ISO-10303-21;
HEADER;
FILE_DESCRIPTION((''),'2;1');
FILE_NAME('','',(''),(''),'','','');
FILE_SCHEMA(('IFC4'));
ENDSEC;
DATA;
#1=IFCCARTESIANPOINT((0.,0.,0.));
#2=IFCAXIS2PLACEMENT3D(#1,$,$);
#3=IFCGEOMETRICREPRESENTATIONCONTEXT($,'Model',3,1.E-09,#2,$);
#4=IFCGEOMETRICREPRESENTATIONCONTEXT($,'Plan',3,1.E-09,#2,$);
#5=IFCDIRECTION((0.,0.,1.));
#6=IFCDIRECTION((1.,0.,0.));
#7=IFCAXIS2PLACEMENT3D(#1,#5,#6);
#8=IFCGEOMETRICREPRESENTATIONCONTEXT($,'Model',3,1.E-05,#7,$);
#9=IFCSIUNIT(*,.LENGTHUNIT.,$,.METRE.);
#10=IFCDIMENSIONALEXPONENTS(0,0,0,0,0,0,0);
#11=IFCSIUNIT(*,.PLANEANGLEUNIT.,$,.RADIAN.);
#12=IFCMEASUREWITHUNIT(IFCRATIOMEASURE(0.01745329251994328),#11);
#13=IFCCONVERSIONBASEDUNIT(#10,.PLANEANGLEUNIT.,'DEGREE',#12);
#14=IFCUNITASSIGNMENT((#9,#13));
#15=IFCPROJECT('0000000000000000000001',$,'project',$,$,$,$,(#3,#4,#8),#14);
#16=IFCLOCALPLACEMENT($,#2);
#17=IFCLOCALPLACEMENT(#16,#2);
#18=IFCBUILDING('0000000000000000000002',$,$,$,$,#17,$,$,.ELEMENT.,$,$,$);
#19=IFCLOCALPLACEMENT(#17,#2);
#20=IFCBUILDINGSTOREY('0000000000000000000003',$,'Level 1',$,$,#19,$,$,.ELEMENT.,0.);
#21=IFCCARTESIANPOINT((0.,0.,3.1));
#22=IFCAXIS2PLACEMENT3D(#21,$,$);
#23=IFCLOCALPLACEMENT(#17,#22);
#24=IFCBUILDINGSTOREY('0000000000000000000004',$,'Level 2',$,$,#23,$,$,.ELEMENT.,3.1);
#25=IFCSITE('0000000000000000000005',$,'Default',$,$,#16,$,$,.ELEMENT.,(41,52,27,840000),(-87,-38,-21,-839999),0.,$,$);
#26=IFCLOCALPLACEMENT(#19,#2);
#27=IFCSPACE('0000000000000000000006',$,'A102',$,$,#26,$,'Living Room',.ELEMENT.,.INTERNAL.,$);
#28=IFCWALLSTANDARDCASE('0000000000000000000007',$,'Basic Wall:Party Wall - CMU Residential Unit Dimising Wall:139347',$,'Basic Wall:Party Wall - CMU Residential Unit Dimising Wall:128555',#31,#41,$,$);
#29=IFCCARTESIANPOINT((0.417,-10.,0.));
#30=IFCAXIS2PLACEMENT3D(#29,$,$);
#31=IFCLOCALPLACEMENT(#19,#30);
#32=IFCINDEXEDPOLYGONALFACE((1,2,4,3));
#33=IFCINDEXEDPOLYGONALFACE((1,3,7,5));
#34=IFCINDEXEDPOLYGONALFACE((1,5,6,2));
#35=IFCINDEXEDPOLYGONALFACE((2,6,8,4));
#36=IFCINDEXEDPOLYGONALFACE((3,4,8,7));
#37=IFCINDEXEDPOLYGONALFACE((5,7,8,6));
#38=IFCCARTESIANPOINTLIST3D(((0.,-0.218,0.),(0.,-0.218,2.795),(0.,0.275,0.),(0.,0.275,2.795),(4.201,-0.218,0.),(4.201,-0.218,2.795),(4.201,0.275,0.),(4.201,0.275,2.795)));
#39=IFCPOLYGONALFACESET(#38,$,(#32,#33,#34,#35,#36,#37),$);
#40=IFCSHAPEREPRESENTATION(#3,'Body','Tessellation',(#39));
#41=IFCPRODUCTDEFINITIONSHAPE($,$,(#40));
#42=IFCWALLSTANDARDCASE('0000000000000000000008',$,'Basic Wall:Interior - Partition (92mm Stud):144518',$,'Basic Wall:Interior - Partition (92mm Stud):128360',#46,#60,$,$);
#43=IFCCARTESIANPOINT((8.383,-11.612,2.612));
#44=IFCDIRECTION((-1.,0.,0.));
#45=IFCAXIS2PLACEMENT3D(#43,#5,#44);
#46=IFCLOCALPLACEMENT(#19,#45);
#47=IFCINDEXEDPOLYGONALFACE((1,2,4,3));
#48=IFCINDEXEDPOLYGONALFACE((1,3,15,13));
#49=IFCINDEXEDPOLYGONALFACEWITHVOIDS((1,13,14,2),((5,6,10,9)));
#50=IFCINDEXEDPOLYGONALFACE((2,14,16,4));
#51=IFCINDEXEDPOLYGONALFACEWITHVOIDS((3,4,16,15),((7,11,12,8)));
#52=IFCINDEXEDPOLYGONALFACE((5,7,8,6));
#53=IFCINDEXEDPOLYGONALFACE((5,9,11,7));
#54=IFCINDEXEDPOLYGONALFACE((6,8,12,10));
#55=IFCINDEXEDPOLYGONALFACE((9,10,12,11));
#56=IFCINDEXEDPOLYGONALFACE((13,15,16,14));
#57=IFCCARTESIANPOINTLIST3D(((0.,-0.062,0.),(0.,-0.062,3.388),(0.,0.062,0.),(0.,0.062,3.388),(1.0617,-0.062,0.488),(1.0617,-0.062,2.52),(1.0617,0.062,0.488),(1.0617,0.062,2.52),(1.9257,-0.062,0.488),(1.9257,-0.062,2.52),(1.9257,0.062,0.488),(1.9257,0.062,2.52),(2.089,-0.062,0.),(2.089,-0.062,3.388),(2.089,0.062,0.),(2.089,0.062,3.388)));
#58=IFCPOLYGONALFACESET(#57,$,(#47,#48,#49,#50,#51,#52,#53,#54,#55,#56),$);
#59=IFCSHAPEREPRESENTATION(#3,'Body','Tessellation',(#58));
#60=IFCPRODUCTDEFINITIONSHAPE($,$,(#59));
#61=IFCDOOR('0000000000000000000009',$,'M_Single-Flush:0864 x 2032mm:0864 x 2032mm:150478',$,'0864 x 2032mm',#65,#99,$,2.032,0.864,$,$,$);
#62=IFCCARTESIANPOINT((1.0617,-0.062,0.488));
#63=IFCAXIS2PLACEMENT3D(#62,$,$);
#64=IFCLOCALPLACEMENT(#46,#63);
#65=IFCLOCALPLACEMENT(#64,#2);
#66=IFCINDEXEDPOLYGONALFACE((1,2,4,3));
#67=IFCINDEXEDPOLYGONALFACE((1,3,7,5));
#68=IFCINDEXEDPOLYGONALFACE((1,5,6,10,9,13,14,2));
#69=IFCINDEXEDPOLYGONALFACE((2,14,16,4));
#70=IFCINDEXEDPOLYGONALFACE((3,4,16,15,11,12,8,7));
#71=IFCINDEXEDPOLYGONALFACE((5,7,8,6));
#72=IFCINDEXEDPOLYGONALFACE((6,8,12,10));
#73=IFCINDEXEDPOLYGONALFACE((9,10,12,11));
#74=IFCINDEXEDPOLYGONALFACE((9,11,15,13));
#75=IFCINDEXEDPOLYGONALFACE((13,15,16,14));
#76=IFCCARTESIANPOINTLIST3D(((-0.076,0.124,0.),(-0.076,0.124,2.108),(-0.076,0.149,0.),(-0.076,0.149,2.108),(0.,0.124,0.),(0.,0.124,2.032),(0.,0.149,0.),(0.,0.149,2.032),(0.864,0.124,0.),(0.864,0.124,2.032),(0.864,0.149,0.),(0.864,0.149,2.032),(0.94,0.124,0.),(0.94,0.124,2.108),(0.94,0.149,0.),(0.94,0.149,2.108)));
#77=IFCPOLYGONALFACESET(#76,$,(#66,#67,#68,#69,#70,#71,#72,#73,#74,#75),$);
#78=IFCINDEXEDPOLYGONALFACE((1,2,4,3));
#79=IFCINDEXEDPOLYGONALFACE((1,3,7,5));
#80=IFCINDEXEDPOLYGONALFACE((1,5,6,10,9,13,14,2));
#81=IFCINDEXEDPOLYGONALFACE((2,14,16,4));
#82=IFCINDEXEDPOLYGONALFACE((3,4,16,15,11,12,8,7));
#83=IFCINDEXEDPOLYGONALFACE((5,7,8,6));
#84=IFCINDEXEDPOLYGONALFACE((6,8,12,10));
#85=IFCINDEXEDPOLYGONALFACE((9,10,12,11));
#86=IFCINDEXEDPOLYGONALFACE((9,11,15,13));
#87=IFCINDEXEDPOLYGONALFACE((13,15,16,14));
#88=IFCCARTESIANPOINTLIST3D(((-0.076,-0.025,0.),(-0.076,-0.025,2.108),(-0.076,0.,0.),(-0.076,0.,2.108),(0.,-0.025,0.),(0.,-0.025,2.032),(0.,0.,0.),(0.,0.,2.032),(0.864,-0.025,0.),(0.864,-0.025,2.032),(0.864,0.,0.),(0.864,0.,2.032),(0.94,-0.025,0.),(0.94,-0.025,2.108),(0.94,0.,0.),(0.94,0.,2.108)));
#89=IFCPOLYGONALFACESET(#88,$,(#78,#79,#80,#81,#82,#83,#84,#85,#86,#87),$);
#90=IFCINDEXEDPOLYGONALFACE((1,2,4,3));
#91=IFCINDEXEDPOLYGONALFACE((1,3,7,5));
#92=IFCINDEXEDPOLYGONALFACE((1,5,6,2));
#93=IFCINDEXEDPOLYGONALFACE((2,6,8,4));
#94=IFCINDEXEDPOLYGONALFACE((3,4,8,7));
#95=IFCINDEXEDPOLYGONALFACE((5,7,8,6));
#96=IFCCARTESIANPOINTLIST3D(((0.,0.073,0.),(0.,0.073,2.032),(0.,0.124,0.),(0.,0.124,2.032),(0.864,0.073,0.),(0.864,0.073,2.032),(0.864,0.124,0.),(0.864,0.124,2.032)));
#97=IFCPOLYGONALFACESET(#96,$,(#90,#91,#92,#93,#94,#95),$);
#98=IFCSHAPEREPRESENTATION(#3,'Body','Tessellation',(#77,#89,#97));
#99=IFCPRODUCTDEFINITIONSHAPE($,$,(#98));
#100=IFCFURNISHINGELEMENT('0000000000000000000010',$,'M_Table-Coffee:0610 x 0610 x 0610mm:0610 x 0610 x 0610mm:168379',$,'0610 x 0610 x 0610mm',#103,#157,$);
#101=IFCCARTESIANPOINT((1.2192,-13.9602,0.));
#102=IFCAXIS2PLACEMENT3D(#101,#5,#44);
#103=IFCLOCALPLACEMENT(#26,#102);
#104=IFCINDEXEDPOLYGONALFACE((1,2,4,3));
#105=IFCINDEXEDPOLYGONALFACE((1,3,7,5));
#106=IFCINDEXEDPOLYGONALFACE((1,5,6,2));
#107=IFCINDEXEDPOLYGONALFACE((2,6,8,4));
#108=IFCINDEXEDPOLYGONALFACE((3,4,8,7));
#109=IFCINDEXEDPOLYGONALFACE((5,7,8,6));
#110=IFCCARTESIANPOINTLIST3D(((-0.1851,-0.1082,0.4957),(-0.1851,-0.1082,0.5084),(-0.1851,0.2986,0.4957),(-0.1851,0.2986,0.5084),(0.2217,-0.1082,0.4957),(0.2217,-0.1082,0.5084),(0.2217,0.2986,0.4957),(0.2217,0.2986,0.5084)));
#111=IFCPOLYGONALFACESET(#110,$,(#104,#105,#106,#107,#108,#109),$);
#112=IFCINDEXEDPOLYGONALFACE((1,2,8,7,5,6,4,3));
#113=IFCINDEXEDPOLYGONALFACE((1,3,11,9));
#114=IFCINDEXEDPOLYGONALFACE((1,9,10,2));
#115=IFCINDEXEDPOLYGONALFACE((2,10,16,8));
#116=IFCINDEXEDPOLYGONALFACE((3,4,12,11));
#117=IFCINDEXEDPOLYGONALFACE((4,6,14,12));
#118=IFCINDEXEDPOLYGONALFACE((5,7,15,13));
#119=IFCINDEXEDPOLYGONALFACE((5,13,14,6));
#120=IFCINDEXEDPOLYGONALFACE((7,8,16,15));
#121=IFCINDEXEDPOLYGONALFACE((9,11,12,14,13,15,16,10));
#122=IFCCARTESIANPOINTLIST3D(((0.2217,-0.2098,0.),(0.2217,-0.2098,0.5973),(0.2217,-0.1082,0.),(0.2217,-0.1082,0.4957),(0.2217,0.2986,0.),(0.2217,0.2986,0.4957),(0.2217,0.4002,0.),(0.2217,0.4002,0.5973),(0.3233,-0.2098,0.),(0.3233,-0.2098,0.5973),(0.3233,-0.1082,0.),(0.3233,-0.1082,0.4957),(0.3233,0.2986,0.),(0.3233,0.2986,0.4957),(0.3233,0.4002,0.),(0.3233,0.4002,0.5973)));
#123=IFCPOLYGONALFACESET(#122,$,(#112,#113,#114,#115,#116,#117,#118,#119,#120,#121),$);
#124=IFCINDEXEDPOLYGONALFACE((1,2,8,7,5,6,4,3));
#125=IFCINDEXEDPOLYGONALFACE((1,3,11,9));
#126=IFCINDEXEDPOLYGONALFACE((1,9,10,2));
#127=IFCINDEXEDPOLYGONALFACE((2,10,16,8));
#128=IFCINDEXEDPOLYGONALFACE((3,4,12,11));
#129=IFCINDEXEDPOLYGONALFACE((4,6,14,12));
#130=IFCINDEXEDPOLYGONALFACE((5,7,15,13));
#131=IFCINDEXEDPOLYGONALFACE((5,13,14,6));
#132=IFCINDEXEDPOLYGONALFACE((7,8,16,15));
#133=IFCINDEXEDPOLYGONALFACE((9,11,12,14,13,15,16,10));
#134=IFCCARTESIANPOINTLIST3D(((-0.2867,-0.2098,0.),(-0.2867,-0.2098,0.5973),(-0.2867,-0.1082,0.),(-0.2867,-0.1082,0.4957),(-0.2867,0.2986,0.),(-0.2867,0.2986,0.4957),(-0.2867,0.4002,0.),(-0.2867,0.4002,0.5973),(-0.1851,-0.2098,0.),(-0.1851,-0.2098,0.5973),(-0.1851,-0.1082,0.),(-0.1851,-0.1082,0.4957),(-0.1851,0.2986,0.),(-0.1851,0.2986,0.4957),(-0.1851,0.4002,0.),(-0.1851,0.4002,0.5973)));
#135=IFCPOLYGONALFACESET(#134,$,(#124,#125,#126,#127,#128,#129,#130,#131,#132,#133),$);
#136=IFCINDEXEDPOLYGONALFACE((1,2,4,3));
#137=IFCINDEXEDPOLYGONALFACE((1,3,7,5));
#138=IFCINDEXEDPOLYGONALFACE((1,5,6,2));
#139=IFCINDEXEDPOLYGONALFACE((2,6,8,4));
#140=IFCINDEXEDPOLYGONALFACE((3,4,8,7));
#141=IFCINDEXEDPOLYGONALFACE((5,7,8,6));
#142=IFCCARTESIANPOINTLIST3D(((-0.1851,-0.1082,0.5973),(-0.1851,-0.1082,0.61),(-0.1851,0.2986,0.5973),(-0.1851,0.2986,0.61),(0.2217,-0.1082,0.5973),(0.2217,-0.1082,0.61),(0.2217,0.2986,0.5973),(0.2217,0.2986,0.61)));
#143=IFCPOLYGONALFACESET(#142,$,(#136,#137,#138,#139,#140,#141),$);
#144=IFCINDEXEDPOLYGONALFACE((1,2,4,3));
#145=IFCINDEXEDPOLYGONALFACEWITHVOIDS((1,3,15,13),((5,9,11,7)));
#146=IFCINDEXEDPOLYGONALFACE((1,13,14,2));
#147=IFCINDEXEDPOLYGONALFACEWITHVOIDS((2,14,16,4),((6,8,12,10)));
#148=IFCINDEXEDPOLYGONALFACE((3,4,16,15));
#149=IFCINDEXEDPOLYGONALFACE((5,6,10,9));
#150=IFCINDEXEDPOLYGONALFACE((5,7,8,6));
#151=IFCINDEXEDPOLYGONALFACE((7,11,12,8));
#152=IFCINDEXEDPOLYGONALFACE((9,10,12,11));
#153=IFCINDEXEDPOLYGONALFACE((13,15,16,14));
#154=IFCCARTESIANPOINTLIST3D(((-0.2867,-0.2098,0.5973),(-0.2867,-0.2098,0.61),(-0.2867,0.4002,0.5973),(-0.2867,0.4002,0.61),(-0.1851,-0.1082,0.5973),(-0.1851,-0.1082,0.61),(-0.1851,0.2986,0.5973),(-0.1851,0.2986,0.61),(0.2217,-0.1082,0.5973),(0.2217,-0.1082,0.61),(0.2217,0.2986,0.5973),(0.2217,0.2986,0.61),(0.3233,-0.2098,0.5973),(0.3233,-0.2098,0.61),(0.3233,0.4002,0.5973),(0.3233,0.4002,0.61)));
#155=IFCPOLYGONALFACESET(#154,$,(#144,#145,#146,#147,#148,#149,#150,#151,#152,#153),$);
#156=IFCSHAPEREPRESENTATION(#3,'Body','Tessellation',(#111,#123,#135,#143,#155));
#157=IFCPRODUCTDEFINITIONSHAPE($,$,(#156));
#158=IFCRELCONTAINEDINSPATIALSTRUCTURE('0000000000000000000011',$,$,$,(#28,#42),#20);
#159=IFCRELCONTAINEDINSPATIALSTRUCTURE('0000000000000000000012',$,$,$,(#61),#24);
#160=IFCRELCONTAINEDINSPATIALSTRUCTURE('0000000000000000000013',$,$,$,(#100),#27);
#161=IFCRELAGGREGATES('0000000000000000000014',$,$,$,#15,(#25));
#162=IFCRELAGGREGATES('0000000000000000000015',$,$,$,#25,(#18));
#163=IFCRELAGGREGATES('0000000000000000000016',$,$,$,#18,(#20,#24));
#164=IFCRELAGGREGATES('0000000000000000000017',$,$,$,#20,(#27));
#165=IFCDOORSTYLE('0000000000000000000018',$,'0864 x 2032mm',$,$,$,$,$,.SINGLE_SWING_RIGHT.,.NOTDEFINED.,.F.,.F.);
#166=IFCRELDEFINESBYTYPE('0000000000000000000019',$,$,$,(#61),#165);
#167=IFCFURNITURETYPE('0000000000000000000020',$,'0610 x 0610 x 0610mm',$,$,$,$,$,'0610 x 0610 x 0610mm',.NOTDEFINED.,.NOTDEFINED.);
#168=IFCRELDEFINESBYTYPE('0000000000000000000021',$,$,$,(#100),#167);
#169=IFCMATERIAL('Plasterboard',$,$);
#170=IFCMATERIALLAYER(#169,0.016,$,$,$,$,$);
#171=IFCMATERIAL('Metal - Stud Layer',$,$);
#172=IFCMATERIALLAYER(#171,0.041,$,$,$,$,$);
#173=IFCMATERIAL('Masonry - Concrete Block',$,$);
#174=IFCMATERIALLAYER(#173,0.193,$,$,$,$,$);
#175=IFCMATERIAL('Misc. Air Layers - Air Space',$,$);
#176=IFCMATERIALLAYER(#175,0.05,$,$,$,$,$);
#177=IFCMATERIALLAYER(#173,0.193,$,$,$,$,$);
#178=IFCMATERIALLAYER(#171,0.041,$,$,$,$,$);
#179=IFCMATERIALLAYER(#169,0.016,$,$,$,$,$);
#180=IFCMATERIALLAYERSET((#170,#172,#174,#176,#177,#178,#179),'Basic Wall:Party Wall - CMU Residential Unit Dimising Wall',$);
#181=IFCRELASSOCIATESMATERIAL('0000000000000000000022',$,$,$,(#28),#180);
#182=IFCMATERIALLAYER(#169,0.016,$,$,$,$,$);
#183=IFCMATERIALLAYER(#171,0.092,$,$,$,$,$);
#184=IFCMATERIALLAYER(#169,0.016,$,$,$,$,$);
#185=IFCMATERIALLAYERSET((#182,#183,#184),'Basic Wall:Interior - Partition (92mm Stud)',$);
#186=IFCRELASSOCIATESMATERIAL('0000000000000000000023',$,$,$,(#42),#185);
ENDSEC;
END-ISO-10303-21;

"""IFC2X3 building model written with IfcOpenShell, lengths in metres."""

from ifc_helpers import new_model, entity, si_unit, converted_unit, frame, frame_2d, origin, origin_with_axes, origin_2d_with_axis, place, context, project, spatial, polyline, rectangle, outline, extrude, clip, bounded_halfspace, source, transform, mapped, material, layer, layer_set, layer_usage, type_object, type_shapes, element, fill, save


model = new_model("IFC2X3")

# Units and contexts
model_context_1 = context("Model", 3, precision=1e-09, world=origin())
plan_context = context("Plan", 3, precision=1e-09, world=origin())
model_context_2 = context("Model", 3, precision=1e-05, world=origin_with_axes())
ifc_project = project(units=[si_unit("LENGTHUNIT", "METRE"), converted_unit("PLANEANGLEUNIT", "DEGREE", entity("IfcRatioMeasure", 0.01745329251994328), si_unit("PLANEANGLEUNIT", "RADIAN"), dimensions=[0, 0, 0, 0, 0, 0, 0])], contexts=[model_context_1, plan_context, model_context_2])

# Site, building, storey
site_placement = place(None, origin())
site = spatial("IfcSite", under=ifc_project, at=site_placement, Name="Default", CompositionType="ELEMENT", RefLatitude=(41, 52, 27, 840000), RefLongitude=(-87, -38, -21, -839999), RefElevation=0.0)
building_placement = place(site_placement, origin())
building = spatial("IfcBuilding", under=site, at=building_placement, CompositionType="ELEMENT")
storey_1_placement = place(building_placement, origin())
storey_1 = spatial("IfcBuildingStorey", under=building, at=storey_1_placement, Name="Level 1", CompositionType="ELEMENT", Elevation=0.0)

# Shared definitions
ifc_material_1 = material(Name="Misc. Air Layers - Air Space")
ifc_material_2 = material(Name="Masonry - Concrete Block")
ifc_material_3 = material(Name="Metal - Stud Layer")
ifc_material_4 = material(Name="Plasterboard")

# Wall
ifc_layer_1 = layer(ifc_material_4, 0.016)
ifc_layer_2 = layer(ifc_material_3, 0.041)
ifc_layer_3 = layer(ifc_material_2, 0.193)
ifc_layer_4 = layer(ifc_material_1, 0.05)
ifc_layer_5 = layer(ifc_material_2, 0.193)
ifc_layer_6 = layer(ifc_material_3, 0.041)
ifc_layer_7 = layer(ifc_material_4, 0.016)
ifc_layer_set_1 = layer_set([ifc_layer_1, ifc_layer_2, ifc_layer_3, ifc_layer_4, ifc_layer_5, ifc_layer_6, ifc_layer_7], Name="Basic Wall:Party Wall - CMU Residential Unit Dimising Wall")
ifc_layer_usage_1 = layer_usage(ifc_layer_set_1, "AXIS2", "NEGATIVE", 0.275)
wall_1_placement = place(storey_1_placement, frame((0.417, -10.0, 0.0)))
element("IfcWallStandardCase", 1, at=wall_1_placement, inside=storey_1, material=ifc_layer_usage_1, Name="Basic Wall:Party Wall - CMU Residential Unit Dimising Wall:139347", ObjectType="Basic Wall:Party Wall - CMU Residential Unit Dimising Wall:128555", context=model_context_1, shape_type="Clipping", body=[
    clip(clip(extrude(rectangle(XDim=4.201, YDim=0.55, at=frame_2d((2.1005, 0.0), x_axis=(-1.0, 0.0))), origin(), (0.0, 0.0, 1.0), 2.795), bounded_halfspace(frame((0.0, -0.218, 0.0), z_axis=(0.0, 1.0, 0.0), x_axis=(-1.0, 0.0, 0.0)), True, frame((0.0, -0.218, 0.0), z_axis=(0.0, 1.0, 0.0), x_axis=(-1.0, 0.0, 0.0)), polyline([(0.0, 0.0), (0.0, 2.795), (-4.201, 2.795), (-4.201, 0.0), (0.0, 0.0)]))), bounded_halfspace(frame((4.201, 0.275, 0.0), z_axis=(-1.0, 0.0, 0.0), x_axis=(0.0, -1.0, 0.0)), True, frame((4.201, 0.275, 0.0), z_axis=(-1.0, 0.0, 0.0), x_axis=(0.0, -1.0, 0.0)), polyline([(0.0, 0.0), (0.493, 0.0), (0.493, 2.795), (0.0, 2.795), (0.0, 0.0)]))),
])

# Shared definitions
ifc_layer_8 = layer(ifc_material_4, 0.016)
ifc_layer_9 = layer(ifc_material_3, 0.092)
ifc_layer_10 = layer(ifc_material_4, 0.016)
ifc_layer_set_2 = layer_set([ifc_layer_8, ifc_layer_9, ifc_layer_10], Name="Basic Wall:Interior - Partition (92mm Stud)")

# Wall, opening
ifc_layer_usage_2 = layer_usage(ifc_layer_set_2, "AXIS2", "NEGATIVE", 0.062)
wall_2_placement = place(storey_1_placement, frame((8.383, -11.612, 2.612), z_axis=(0.0, 0.0, 1.0), x_axis=(-1.0, 0.0, 0.0)))
wall_2 = element("IfcWallStandardCase", 2, at=wall_2_placement, inside=storey_1, material=ifc_layer_usage_2, Name="Basic Wall:Interior - Partition (92mm Stud):144518", ObjectType="Basic Wall:Interior - Partition (92mm Stud):128360", context=model_context_1, shape_type="SweptSolid", body=[
    extrude(rectangle(XDim=2.089, YDim=0.124, at=frame_2d((1.0445, 0.0), x_axis=(-1.0, 0.0))), origin(), (0.0, 0.0, 1.0), 3.388),
])
opening_1_placement = place(wall_2_placement, frame((1.0617, -0.062, 0.488)))
opening_1 = element("IfcOpeningElement", 3, at=opening_1_placement, cuts=wall_2, ObjectType="Opening", context=model_context_1, shape_type="SweptSolid", body=[
    extrude(rectangle(XDim=0.864, YDim=2.032, at=frame_2d((1.016, 0.432), x_axis=(0.0, 1.0))), frame((0.0, 0.0, 0.0), z_axis=(0.0, 1.0, 0.0), x_axis=(0.0, 0.0, 1.0)), (0.0, 0.0, 1.0), 0.124),
])

# Shared definitions
storey_2_placement = place(building_placement, frame((0.0, 0.0, 3.1)))
storey_2 = spatial("IfcBuildingStorey", under=building, at=storey_2_placement, Name="Level 2", CompositionType="ELEMENT", Elevation=3.1)

# Door
door_style_1 = type_object("IfcDoorStyle", Name="0864 x 2032mm", ConstructionType="NOTDEFINED", OperationType="SINGLE_SWING_RIGHT", ParameterTakesPrecedence=False, Sizeable=False)
shared_shape_1 = source(origin(), model_context_1, "Body", "SweptSolid", [
    extrude(outline(polyline([(-0.508, -1.073), (0.508, -1.073), (0.508, 1.035), (0.432, 1.035), (0.432, -0.997), (-0.432, -0.997), (-0.432, 1.035), (-0.508, 1.035), (-0.508, -1.073)])), frame((0.432, 0.124, 1.035), z_axis=(0.0, 1.0, 0.0), x_axis=(1.0, 0.0, 0.0)), (0.0, 0.0, 1.0), 0.025),
    extrude(outline(polyline([(-1.073, -0.508), (1.035, -0.508), (1.035, -0.432), (-0.997, -0.432), (-0.997, 0.432), (1.035, 0.432), (1.035, 0.508), (-1.073, 0.508), (-1.073, -0.508)])), frame((0.432, -0.025, 1.035), z_axis=(0.0, 1.0, 0.0), x_axis=(0.0, 0.0, -1.0)), (0.0, 0.0, 1.0), 0.025),
    extrude(rectangle(XDim=0.051, YDim=0.864, at=origin_2d_with_axis()), frame((0.432, 0.0985, 0.0), z_axis=(0.0, 0.0, 1.0), x_axis=(0.0, 1.0, 0.0)), (0.0, 0.0, 1.0), 2.032),
])
type_shapes(door_style_1, [shared_shape_1])
door_1_placement = place(opening_1_placement, origin())
door_1 = element("IfcDoor", 4, at=door_1_placement, inside=storey_2, type_object=door_style_1, Name="M_Single-Flush:0864 x 2032mm:0864 x 2032mm:150478", ObjectType="0864 x 2032mm", OverallHeight=2.032, OverallWidth=0.864, context=model_context_1, shape_type="MappedRepresentation", body=[
    mapped(shared_shape_1, transform((0.0, 0.0, 0.0), scale=1.0)),
])
fill(opening_1, door_1)

# Shared definitions
space_1_placement = place(storey_1_placement, origin())
space_1 = spatial("IfcSpace", under=storey_1, at=space_1_placement, Name="A102", LongName="Living Room", CompositionType="ELEMENT", InteriorOrExteriorSpace="INTERNAL")

# Furnishing element
furniture_type_1 = type_object("IfcFurnitureType", Name="0610 x 0610 x 0610mm", ElementType="0610 x 0610 x 0610mm", AssemblyPlace="NOTDEFINED")
shared_shape_2 = source(origin(), model_context_1, "Body", "SweptSolid", [
    extrude(rectangle(XDim=0.4068, YDim=0.4068, at=origin_2d_with_axis()), frame((0.0183, 0.0952, 0.4957), z_axis=(0.0, 0.0, 1.0), x_axis=(-1.0, 0.0, 0.0)), (0.0, 0.0, 1.0), 0.0127),
    extrude(outline(polyline([(-0.2732, -0.305), (0.324, -0.305), (0.324, 0.305), (-0.2732, 0.305), (-0.2732, 0.2034), (0.2225, 0.2034), (0.2225, -0.2034), (-0.2732, -0.2034), (-0.2732, -0.305)])), frame((0.2217, 0.0952, 0.2732), z_axis=(1.0, 0.0, 0.0), x_axis=(0.0, 0.0, 1.0)), (0.0, 0.0, 1.0), 0.1016),
    extrude(outline(polyline([(-0.305, -0.3241), (0.305, -0.3241), (0.305, 0.2733), (0.2034, 0.2733), (0.2034, -0.2224), (-0.2034, -0.2224), (-0.2034, 0.2733), (-0.305, 0.2733), (-0.305, -0.3241)])), frame((-0.2867, 0.0952, 0.2733), z_axis=(1.0, 0.0, 0.0), x_axis=(0.0, -1.0, 0.0)), (0.0, 0.0, 1.0), 0.1016),
    extrude(rectangle(XDim=0.4068, YDim=0.4068, at=origin_2d_with_axis()), frame((0.0183, 0.0952, 0.5973), z_axis=(0.0, 0.0, 1.0), x_axis=(-1.0, 0.0, 0.0)), (0.0, 0.0, 1.0), 0.0127),
    extrude(outline(polyline([(-0.305, -0.305), (0.305, -0.305), (0.305, 0.305), (-0.305, 0.305), (-0.305, -0.305)]), holes=[polyline([(-0.2034, -0.2034), (-0.2034, 0.2034), (0.2034, 0.2034), (0.2034, -0.2034), (-0.2034, -0.2034)])]), frame((0.0183, 0.0952, 0.5973), z_axis=(0.0, 0.0, 1.0), x_axis=(-1.0, 0.0, 0.0)), (0.0, 0.0, 1.0), 0.0127),
])
type_shapes(furniture_type_1, [shared_shape_2])
for number, where, z_axis, x_axis, name in (
    (5, (1.2192, -13.9602, 0.0), (0.0, 0.0, 1.0), (-1.0, 0.0, 0.0), "M_Table-Coffee:0610 x 0610 x 0610mm:0610 x 0610 x 0610mm:168379"),
):
    element("IfcFurnishingElement", number, at=place(space_1_placement, frame(where, z_axis=z_axis, x_axis=x_axis)), inside=space_1, type_object=furniture_type_1, Name=name, ObjectType="0610 x 0610 x 0610mm", context=model_context_1, shape_type="MappedRepresentation", body=[
        mapped(shared_shape_2, transform((0.0, 0.0, 0.0), scale=1.0)),
    ])

save(model, "model.ifc")
